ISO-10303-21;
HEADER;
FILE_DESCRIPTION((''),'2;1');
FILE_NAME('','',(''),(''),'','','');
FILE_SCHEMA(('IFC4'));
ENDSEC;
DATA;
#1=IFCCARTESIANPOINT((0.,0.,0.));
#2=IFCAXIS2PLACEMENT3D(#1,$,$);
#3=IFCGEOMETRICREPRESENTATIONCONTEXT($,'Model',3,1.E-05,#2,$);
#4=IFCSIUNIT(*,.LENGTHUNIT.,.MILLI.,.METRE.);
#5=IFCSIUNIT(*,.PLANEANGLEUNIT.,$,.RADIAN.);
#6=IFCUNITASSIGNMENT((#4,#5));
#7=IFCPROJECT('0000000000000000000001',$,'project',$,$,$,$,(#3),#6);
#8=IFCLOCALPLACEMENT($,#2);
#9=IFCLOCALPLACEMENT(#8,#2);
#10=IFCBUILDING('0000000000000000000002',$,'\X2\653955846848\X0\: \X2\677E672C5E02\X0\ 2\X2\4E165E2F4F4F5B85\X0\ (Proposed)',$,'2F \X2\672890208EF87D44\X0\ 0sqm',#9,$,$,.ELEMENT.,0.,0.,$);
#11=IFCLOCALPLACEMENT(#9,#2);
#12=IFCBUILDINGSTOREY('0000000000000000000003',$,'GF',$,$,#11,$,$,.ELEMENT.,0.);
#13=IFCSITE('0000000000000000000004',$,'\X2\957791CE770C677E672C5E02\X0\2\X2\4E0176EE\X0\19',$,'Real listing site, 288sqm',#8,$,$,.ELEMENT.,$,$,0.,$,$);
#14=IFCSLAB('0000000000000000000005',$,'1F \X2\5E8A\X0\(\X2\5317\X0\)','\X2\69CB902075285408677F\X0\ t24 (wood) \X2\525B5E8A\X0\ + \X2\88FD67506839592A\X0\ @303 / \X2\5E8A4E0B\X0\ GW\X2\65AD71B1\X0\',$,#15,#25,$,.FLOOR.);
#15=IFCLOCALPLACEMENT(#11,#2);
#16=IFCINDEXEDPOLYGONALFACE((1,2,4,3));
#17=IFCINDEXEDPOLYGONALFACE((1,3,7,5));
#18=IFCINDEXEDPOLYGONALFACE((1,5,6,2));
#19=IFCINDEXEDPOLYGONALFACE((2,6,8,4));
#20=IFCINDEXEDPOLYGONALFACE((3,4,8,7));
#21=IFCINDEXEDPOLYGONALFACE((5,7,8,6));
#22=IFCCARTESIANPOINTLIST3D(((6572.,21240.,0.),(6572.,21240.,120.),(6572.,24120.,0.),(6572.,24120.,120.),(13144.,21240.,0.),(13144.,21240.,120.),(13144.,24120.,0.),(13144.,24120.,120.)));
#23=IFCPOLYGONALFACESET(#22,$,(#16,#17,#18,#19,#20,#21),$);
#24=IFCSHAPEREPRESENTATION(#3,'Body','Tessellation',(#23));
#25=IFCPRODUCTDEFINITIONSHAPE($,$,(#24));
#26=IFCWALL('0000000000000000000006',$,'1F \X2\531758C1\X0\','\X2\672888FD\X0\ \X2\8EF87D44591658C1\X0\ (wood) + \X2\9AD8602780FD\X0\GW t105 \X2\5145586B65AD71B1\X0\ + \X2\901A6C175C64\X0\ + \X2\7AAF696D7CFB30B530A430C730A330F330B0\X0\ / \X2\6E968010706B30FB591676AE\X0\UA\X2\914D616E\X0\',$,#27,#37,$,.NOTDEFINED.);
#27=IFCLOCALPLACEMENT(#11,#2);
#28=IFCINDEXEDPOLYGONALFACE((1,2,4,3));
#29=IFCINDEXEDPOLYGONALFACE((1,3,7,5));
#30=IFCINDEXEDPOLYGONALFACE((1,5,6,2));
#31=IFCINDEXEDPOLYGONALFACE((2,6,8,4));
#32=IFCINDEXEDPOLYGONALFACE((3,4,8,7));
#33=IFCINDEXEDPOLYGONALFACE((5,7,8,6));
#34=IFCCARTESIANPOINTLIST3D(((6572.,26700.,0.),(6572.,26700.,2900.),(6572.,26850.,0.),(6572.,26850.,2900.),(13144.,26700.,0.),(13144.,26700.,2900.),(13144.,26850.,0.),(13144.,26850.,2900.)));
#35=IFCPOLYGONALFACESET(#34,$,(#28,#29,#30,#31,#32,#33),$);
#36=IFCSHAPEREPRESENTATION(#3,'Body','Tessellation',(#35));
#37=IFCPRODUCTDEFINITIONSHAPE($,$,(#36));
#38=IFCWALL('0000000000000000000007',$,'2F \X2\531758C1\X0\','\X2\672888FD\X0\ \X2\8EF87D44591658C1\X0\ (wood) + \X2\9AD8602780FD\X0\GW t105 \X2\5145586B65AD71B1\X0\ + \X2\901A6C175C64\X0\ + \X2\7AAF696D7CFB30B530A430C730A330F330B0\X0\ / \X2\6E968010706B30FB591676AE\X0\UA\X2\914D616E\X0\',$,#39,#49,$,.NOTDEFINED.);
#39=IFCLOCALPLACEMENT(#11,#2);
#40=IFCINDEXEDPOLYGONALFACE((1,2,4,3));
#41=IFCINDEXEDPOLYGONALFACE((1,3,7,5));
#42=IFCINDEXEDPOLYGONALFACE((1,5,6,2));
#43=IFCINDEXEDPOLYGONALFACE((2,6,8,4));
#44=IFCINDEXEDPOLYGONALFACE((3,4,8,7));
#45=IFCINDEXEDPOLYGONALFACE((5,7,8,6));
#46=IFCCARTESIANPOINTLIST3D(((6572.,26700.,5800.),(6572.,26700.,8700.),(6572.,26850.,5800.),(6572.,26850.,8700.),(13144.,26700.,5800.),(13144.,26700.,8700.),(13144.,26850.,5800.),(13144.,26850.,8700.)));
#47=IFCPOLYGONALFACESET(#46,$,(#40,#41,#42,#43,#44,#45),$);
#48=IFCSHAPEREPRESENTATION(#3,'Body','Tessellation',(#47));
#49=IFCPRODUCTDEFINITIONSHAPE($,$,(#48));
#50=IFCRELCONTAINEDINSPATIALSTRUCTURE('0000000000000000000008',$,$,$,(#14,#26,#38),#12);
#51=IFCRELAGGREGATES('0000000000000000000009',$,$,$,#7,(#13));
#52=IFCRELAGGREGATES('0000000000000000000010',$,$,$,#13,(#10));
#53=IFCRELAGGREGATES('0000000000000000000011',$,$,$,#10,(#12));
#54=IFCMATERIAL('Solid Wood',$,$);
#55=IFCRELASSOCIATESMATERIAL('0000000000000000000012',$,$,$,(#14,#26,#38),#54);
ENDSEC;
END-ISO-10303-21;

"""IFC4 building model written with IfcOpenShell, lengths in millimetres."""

from ifc_helpers import new_model, si_unit, frame, frame_2d, origin, place, context, project, spatial, rectangle, extrude, material, element, save


model = new_model("IFC4")

# Units and contexts
model_context = context("Model", 3, precision=1e-05, world=origin())
ifc_project = project(units=[si_unit("LENGTHUNIT", "METRE", prefix="MILLI"), si_unit("PLANEANGLEUNIT", "RADIAN")], contexts=[model_context])

# Site, building, storey
site_placement = place(None, origin())
site = spatial("IfcSite", under=ifc_project, at=site_placement, Name="長野県松本市2丁目19", ObjectType="Real listing site, 288sqm", CompositionType="ELEMENT", RefElevation=0.0)
building_placement = place(site_placement, origin())
building = spatial("IfcBuilding", under=site, at=building_placement, Name="改善案: 松本市 2世帯住宅 (Proposed)", ObjectType="2F 木造軸組 0sqm", CompositionType="ELEMENT", ElevationOfRefHeight=0.0, ElevationOfTerrain=0.0)
storey_placement = place(building_placement, origin())
storey = spatial("IfcBuildingStorey", under=building, at=storey_placement, Name="GF", CompositionType="ELEMENT", Elevation=0.0)

# Slab
ifc_material_1 = material(Name="Solid Wood")
slab_1_placement = place(storey_placement, frame((3286.0, 10620.0, 0.0)))
element("IfcSlab", 1, at=slab_1_placement, inside=storey, material=ifc_material_1, Name="1F 床(北)", Description="構造用合板 t24 (wood) 剛床 + 製材根太 @303 / 床下 GW断熱", PredefinedType="FLOOR", context=model_context, shape_type="SweptSolid", body=[
    extrude(rectangle(XDim=6572.0, YDim=2880.0, at=frame_2d((3286.0, 1440.0))), frame((3286.0, 10620.0, 0.0)), (0.0, 0.0, 1.0), 120.0),
])

# Wall
wall_1_placement = place(storey_placement, frame((3286.0, 13350.0, 0.0)))
element("IfcWall", 2, at=wall_1_placement, inside=storey, material=ifc_material_1, Name="1F 北壁", Description="木製 軸組外壁 (wood) + 高性能GW t105 充填断熱 + 通気層 + 窯業系サイディング / 準耐火・外皮UA配慮", PredefinedType="NOTDEFINED", context=model_context, shape_type="SweptSolid", body=[
    extrude(rectangle(XDim=6572.0, YDim=150.0, at=frame_2d((3286.0, 75.0))), frame((3286.0, 13350.0, 0.0)), (0.0, 0.0, 1.0), 2900.0),
])

# Wall
wall_2_placement = place(storey_placement, frame((3286.0, 13350.0, 2900.0)))
element("IfcWall", 3, at=wall_2_placement, inside=storey, material=ifc_material_1, Name="2F 北壁", Description="木製 軸組外壁 (wood) + 高性能GW t105 充填断熱 + 通気層 + 窯業系サイディング / 準耐火・外皮UA配慮", PredefinedType="NOTDEFINED", context=model_context, shape_type="SweptSolid", body=[
    extrude(rectangle(XDim=6572.0, YDim=150.0, at=frame_2d((3286.0, 75.0))), frame((3286.0, 13350.0, 2900.0)), (0.0, 0.0, 1.0), 2900.0),
])

save(model, "model.ifc")
